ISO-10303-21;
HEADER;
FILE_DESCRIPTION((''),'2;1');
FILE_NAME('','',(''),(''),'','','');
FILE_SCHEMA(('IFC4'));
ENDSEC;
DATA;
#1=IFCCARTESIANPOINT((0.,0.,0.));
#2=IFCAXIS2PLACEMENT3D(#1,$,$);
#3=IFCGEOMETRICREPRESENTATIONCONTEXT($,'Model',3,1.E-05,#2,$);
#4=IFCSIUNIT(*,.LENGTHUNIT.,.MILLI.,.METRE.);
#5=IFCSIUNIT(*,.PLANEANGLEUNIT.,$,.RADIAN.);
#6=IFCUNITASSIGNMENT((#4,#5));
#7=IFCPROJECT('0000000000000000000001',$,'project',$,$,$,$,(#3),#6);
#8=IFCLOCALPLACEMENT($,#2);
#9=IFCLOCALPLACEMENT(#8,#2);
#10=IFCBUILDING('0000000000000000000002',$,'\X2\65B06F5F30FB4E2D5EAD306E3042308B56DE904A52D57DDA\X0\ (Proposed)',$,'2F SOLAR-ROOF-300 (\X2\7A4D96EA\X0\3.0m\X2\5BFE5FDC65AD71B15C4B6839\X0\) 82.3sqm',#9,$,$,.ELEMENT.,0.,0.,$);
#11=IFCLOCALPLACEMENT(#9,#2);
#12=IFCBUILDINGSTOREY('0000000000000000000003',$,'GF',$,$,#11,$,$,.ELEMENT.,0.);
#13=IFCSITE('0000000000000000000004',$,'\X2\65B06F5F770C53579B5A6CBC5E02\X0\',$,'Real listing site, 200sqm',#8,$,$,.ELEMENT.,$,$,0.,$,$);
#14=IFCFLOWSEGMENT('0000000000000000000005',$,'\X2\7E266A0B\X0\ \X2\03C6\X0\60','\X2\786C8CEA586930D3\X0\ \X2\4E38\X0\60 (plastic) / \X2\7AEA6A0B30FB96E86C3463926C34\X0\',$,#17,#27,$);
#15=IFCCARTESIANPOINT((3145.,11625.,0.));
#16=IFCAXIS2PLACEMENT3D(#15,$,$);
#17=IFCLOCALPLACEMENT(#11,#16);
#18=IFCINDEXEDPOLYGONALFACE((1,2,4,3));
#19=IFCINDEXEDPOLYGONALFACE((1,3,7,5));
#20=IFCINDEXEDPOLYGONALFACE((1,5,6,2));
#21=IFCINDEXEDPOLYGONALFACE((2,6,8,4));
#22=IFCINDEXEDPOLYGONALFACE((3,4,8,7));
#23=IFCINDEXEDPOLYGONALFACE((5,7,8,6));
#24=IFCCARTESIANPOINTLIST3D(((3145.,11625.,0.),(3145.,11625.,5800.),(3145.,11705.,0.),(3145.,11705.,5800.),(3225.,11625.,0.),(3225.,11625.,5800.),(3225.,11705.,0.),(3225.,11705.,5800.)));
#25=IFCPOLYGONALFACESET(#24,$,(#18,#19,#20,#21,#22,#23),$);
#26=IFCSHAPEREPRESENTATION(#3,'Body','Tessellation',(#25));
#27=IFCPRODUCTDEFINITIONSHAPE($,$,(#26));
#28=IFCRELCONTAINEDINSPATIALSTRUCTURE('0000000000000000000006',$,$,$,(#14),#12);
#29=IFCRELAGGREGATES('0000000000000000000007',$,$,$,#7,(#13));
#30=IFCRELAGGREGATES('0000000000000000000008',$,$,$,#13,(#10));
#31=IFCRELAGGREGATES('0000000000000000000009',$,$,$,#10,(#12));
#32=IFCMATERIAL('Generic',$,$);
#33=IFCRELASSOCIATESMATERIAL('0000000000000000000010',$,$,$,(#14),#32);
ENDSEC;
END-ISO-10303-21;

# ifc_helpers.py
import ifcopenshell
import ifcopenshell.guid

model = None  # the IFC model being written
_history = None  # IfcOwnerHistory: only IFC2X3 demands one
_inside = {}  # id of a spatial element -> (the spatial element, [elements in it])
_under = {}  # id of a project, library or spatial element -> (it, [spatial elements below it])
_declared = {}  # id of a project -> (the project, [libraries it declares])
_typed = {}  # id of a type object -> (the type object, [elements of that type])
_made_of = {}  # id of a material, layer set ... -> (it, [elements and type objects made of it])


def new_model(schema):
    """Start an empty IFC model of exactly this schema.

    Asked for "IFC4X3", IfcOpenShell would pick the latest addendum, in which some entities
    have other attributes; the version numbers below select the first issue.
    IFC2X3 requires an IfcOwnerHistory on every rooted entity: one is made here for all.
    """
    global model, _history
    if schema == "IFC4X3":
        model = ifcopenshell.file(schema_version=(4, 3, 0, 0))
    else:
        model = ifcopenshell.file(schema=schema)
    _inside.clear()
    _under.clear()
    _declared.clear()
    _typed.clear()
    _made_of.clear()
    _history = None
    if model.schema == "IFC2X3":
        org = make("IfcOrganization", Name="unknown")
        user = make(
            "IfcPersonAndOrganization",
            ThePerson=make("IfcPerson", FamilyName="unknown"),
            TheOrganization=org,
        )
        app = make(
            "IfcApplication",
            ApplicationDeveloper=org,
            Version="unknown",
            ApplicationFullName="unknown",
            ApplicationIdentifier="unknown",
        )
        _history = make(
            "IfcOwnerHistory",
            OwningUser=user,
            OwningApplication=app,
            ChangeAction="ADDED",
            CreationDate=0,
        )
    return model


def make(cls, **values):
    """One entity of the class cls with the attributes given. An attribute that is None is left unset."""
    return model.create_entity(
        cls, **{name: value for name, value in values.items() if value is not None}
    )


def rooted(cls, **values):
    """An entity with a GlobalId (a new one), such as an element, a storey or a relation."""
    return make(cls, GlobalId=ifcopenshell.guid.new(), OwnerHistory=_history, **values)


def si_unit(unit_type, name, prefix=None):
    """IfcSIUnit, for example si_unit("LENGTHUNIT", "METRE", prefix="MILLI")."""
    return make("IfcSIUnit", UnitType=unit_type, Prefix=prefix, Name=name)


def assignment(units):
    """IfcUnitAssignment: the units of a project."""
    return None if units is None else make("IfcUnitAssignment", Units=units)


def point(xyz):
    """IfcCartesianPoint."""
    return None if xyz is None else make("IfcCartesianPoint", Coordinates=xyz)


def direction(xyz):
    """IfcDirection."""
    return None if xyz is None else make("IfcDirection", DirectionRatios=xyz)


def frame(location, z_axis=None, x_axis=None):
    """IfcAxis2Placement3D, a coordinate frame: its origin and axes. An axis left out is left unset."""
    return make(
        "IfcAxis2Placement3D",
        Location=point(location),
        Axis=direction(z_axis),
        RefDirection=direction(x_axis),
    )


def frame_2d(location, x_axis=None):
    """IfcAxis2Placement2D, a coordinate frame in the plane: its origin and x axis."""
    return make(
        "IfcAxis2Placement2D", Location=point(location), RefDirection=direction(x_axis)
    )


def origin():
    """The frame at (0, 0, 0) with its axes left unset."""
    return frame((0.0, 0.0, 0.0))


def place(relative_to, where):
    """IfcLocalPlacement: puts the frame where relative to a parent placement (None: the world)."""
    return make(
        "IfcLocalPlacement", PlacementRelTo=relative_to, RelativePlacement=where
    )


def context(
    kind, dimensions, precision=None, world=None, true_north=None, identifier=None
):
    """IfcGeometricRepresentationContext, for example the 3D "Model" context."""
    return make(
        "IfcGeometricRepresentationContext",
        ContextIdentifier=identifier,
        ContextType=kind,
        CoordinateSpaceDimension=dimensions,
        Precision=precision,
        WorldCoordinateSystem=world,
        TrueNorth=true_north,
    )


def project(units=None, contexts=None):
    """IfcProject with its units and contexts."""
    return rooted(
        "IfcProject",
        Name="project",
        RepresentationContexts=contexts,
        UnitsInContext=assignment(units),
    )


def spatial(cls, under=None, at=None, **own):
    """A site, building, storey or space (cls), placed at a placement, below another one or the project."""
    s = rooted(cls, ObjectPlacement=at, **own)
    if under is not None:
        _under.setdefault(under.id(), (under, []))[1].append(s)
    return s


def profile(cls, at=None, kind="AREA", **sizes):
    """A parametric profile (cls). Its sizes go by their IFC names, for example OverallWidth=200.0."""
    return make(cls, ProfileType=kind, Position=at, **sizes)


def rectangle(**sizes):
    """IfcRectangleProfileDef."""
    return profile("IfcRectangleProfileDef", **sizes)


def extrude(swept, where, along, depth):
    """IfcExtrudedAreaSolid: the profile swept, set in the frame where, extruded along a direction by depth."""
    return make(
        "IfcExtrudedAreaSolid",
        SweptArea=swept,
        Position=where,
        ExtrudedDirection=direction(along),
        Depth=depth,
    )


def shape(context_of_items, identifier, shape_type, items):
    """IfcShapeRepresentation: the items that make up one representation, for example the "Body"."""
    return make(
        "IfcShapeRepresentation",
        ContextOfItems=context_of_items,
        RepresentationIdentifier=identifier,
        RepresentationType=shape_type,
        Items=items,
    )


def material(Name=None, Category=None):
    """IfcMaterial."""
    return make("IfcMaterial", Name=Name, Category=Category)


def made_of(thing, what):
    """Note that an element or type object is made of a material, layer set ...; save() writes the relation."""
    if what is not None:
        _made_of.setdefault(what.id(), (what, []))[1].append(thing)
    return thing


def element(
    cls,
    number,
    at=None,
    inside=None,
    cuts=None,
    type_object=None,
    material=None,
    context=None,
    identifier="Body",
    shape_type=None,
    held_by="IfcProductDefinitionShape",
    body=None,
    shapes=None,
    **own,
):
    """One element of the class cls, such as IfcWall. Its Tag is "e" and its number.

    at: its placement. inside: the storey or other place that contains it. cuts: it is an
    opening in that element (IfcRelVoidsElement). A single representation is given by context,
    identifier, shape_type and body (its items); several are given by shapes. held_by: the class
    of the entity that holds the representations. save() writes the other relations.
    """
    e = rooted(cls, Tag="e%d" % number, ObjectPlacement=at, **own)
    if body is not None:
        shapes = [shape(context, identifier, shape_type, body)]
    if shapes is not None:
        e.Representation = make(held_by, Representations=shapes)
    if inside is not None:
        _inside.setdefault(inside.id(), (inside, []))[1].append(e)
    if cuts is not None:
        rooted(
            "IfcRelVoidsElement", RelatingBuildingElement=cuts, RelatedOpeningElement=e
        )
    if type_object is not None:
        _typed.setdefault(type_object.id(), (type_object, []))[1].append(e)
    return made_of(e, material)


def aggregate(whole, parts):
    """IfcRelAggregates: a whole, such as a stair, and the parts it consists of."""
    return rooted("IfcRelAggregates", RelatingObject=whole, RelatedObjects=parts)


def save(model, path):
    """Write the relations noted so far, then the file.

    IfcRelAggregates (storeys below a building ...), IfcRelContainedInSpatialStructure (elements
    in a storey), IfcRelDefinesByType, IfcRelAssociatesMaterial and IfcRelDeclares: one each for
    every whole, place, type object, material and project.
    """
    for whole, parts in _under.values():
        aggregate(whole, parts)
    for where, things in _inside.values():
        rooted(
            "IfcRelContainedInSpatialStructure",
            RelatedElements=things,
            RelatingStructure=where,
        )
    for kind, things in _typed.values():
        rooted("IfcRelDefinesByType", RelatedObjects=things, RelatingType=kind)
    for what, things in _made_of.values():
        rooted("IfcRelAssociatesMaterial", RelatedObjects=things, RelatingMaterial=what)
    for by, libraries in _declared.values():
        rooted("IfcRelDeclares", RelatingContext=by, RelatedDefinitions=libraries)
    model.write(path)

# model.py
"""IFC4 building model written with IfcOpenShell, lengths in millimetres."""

from ifc_helpers import new_model, si_unit, frame, frame_2d, origin, place, context, project, spatial, rectangle, extrude, material, element, save


model = new_model("IFC4")

# Units and contexts
model_context = context("Model", 3, precision=1e-05, world=origin())
ifc_project = project(units=[si_unit("LENGTHUNIT", "METRE", prefix="MILLI"), si_unit("PLANEANGLEUNIT", "RADIAN")], contexts=[model_context])

# Site, building, storey
site_placement = place(None, origin())
site = spatial("IfcSite", under=ifc_project, at=site_placement, Name="新潟県南魚沼市", ObjectType="Real listing site, 200sqm", CompositionType="ELEMENT", RefElevation=0.0)
building_placement = place(site_placement, origin())
building = spatial("IfcBuilding", under=site, at=building_placement, Name="新潟・中庭のある回遊動線 (Proposed)", ObjectType="2F SOLAR-ROOF-300 (積雪3.0m対応断熱屋根) 82.3sqm", CompositionType="ELEMENT", ElevationOfRefHeight=0.0, ElevationOfTerrain=0.0)
storey_placement = place(building_placement, origin())
storey = spatial("IfcBuildingStorey", under=building, at=storey_placement, Name="GF", CompositionType="ELEMENT", Elevation=0.0)

# Shared definitions
ifc_material_1 = material(Name="Generic")

# Flow segment
flow_segment_placement = place(storey_placement, frame((3145.0, 11625.0, 0.0)))
element("IfcFlowSegment", 1, at=flow_segment_placement, inside=storey, material=ifc_material_1, Name="縦樋 φ60", Description="硬質塩ビ 丸60 (plastic) / 竪樋・雨水排水", context=model_context, shape_type="SweptSolid", body=[
    extrude(rectangle(XDim=80.0, YDim=80.0, at=frame_2d((40.0, 40.0))), frame((3145.0, 11625.0, 0.0)), (0.0, 0.0, 1.0), 5800.0),
])

save(model, "model.ifc")
